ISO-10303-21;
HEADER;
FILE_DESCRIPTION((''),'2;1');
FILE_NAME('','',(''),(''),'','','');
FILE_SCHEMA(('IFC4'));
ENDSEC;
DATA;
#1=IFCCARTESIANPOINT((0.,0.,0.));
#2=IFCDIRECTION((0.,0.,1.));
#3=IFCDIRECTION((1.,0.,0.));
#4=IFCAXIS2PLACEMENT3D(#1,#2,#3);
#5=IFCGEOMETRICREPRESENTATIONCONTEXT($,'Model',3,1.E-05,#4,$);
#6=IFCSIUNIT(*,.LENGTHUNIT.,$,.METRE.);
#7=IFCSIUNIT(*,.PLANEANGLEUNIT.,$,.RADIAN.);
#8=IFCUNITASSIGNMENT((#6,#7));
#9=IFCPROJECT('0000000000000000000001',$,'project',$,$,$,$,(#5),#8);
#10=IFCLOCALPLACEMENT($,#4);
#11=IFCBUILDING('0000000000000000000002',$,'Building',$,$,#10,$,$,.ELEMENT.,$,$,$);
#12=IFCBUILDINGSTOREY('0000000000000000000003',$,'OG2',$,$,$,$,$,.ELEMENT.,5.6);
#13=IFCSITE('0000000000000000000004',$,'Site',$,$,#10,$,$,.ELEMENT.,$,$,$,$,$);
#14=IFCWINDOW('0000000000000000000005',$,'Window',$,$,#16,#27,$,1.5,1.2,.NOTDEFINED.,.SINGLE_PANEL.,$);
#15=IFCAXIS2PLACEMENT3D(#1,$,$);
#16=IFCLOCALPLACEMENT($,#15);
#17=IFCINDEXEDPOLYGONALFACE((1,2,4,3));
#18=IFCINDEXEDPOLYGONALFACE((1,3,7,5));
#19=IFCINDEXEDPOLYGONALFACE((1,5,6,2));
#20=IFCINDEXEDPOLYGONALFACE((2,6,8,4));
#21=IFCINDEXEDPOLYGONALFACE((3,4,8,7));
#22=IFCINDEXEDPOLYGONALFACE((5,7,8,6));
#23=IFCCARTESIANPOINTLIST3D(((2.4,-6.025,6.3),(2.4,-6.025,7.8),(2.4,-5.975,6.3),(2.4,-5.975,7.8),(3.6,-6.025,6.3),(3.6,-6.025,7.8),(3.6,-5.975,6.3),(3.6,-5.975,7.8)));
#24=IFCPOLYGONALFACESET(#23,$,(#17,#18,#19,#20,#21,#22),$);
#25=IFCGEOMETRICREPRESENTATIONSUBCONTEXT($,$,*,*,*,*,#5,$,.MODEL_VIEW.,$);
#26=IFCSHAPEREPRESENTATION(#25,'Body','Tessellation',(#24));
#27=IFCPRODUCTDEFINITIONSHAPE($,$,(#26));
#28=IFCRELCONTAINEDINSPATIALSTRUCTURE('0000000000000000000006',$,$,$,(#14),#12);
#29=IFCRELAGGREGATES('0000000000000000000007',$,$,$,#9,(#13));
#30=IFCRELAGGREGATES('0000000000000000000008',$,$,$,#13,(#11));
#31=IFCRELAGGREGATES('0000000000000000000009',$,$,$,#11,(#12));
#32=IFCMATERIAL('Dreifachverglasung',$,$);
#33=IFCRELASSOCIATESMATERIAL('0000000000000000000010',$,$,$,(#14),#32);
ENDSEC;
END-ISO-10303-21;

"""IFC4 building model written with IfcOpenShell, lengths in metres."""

from ifc_helpers import new_model, si_unit, frame, origin, origin_with_axes, origin_2d, place, context, subcontext, project, spatial, rectangle, extrude, material, element, save


model = new_model("IFC4")

# Units and contexts
model_context = context("Model", 3, precision=1e-05, world=origin_with_axes())
sub_context = subcontext(model_context, None, None, "MODEL_VIEW")
ifc_project = project(units=[si_unit("LENGTHUNIT", "METRE"), si_unit("PLANEANGLEUNIT", "RADIAN")], contexts=[model_context])

# Site, building, storey
placement_1 = place(None, origin_with_axes())
site = spatial("IfcSite", under=ifc_project, at=placement_1, Name="Site", CompositionType="ELEMENT")
building = spatial("IfcBuilding", under=site, at=placement_1, Name="Building", CompositionType="ELEMENT")
storey = spatial("IfcBuildingStorey", under=building, Name="OG2", CompositionType="ELEMENT", Elevation=5.6)

# Window
ifc_material = material(Name="Dreifachverglasung")
placement_2 = place(None, origin_with_axes())
window_placement = place(placement_2, frame((3.0, -6.0, 6.3)))
element("IfcWindow", 1, at=window_placement, inside=storey, material=ifc_material, Name="Window", OverallHeight=1.5, OverallWidth=1.2, PartitioningType="SINGLE_PANEL", PredefinedType="NOTDEFINED", context=sub_context, shape_type="SweptSolid", body=[
    extrude(rectangle(XDim=1.2, YDim=0.05, at=origin_2d()), origin(), (0.0, 0.0, 1.0), 1.5),
])

save(model, "model.ifc")
